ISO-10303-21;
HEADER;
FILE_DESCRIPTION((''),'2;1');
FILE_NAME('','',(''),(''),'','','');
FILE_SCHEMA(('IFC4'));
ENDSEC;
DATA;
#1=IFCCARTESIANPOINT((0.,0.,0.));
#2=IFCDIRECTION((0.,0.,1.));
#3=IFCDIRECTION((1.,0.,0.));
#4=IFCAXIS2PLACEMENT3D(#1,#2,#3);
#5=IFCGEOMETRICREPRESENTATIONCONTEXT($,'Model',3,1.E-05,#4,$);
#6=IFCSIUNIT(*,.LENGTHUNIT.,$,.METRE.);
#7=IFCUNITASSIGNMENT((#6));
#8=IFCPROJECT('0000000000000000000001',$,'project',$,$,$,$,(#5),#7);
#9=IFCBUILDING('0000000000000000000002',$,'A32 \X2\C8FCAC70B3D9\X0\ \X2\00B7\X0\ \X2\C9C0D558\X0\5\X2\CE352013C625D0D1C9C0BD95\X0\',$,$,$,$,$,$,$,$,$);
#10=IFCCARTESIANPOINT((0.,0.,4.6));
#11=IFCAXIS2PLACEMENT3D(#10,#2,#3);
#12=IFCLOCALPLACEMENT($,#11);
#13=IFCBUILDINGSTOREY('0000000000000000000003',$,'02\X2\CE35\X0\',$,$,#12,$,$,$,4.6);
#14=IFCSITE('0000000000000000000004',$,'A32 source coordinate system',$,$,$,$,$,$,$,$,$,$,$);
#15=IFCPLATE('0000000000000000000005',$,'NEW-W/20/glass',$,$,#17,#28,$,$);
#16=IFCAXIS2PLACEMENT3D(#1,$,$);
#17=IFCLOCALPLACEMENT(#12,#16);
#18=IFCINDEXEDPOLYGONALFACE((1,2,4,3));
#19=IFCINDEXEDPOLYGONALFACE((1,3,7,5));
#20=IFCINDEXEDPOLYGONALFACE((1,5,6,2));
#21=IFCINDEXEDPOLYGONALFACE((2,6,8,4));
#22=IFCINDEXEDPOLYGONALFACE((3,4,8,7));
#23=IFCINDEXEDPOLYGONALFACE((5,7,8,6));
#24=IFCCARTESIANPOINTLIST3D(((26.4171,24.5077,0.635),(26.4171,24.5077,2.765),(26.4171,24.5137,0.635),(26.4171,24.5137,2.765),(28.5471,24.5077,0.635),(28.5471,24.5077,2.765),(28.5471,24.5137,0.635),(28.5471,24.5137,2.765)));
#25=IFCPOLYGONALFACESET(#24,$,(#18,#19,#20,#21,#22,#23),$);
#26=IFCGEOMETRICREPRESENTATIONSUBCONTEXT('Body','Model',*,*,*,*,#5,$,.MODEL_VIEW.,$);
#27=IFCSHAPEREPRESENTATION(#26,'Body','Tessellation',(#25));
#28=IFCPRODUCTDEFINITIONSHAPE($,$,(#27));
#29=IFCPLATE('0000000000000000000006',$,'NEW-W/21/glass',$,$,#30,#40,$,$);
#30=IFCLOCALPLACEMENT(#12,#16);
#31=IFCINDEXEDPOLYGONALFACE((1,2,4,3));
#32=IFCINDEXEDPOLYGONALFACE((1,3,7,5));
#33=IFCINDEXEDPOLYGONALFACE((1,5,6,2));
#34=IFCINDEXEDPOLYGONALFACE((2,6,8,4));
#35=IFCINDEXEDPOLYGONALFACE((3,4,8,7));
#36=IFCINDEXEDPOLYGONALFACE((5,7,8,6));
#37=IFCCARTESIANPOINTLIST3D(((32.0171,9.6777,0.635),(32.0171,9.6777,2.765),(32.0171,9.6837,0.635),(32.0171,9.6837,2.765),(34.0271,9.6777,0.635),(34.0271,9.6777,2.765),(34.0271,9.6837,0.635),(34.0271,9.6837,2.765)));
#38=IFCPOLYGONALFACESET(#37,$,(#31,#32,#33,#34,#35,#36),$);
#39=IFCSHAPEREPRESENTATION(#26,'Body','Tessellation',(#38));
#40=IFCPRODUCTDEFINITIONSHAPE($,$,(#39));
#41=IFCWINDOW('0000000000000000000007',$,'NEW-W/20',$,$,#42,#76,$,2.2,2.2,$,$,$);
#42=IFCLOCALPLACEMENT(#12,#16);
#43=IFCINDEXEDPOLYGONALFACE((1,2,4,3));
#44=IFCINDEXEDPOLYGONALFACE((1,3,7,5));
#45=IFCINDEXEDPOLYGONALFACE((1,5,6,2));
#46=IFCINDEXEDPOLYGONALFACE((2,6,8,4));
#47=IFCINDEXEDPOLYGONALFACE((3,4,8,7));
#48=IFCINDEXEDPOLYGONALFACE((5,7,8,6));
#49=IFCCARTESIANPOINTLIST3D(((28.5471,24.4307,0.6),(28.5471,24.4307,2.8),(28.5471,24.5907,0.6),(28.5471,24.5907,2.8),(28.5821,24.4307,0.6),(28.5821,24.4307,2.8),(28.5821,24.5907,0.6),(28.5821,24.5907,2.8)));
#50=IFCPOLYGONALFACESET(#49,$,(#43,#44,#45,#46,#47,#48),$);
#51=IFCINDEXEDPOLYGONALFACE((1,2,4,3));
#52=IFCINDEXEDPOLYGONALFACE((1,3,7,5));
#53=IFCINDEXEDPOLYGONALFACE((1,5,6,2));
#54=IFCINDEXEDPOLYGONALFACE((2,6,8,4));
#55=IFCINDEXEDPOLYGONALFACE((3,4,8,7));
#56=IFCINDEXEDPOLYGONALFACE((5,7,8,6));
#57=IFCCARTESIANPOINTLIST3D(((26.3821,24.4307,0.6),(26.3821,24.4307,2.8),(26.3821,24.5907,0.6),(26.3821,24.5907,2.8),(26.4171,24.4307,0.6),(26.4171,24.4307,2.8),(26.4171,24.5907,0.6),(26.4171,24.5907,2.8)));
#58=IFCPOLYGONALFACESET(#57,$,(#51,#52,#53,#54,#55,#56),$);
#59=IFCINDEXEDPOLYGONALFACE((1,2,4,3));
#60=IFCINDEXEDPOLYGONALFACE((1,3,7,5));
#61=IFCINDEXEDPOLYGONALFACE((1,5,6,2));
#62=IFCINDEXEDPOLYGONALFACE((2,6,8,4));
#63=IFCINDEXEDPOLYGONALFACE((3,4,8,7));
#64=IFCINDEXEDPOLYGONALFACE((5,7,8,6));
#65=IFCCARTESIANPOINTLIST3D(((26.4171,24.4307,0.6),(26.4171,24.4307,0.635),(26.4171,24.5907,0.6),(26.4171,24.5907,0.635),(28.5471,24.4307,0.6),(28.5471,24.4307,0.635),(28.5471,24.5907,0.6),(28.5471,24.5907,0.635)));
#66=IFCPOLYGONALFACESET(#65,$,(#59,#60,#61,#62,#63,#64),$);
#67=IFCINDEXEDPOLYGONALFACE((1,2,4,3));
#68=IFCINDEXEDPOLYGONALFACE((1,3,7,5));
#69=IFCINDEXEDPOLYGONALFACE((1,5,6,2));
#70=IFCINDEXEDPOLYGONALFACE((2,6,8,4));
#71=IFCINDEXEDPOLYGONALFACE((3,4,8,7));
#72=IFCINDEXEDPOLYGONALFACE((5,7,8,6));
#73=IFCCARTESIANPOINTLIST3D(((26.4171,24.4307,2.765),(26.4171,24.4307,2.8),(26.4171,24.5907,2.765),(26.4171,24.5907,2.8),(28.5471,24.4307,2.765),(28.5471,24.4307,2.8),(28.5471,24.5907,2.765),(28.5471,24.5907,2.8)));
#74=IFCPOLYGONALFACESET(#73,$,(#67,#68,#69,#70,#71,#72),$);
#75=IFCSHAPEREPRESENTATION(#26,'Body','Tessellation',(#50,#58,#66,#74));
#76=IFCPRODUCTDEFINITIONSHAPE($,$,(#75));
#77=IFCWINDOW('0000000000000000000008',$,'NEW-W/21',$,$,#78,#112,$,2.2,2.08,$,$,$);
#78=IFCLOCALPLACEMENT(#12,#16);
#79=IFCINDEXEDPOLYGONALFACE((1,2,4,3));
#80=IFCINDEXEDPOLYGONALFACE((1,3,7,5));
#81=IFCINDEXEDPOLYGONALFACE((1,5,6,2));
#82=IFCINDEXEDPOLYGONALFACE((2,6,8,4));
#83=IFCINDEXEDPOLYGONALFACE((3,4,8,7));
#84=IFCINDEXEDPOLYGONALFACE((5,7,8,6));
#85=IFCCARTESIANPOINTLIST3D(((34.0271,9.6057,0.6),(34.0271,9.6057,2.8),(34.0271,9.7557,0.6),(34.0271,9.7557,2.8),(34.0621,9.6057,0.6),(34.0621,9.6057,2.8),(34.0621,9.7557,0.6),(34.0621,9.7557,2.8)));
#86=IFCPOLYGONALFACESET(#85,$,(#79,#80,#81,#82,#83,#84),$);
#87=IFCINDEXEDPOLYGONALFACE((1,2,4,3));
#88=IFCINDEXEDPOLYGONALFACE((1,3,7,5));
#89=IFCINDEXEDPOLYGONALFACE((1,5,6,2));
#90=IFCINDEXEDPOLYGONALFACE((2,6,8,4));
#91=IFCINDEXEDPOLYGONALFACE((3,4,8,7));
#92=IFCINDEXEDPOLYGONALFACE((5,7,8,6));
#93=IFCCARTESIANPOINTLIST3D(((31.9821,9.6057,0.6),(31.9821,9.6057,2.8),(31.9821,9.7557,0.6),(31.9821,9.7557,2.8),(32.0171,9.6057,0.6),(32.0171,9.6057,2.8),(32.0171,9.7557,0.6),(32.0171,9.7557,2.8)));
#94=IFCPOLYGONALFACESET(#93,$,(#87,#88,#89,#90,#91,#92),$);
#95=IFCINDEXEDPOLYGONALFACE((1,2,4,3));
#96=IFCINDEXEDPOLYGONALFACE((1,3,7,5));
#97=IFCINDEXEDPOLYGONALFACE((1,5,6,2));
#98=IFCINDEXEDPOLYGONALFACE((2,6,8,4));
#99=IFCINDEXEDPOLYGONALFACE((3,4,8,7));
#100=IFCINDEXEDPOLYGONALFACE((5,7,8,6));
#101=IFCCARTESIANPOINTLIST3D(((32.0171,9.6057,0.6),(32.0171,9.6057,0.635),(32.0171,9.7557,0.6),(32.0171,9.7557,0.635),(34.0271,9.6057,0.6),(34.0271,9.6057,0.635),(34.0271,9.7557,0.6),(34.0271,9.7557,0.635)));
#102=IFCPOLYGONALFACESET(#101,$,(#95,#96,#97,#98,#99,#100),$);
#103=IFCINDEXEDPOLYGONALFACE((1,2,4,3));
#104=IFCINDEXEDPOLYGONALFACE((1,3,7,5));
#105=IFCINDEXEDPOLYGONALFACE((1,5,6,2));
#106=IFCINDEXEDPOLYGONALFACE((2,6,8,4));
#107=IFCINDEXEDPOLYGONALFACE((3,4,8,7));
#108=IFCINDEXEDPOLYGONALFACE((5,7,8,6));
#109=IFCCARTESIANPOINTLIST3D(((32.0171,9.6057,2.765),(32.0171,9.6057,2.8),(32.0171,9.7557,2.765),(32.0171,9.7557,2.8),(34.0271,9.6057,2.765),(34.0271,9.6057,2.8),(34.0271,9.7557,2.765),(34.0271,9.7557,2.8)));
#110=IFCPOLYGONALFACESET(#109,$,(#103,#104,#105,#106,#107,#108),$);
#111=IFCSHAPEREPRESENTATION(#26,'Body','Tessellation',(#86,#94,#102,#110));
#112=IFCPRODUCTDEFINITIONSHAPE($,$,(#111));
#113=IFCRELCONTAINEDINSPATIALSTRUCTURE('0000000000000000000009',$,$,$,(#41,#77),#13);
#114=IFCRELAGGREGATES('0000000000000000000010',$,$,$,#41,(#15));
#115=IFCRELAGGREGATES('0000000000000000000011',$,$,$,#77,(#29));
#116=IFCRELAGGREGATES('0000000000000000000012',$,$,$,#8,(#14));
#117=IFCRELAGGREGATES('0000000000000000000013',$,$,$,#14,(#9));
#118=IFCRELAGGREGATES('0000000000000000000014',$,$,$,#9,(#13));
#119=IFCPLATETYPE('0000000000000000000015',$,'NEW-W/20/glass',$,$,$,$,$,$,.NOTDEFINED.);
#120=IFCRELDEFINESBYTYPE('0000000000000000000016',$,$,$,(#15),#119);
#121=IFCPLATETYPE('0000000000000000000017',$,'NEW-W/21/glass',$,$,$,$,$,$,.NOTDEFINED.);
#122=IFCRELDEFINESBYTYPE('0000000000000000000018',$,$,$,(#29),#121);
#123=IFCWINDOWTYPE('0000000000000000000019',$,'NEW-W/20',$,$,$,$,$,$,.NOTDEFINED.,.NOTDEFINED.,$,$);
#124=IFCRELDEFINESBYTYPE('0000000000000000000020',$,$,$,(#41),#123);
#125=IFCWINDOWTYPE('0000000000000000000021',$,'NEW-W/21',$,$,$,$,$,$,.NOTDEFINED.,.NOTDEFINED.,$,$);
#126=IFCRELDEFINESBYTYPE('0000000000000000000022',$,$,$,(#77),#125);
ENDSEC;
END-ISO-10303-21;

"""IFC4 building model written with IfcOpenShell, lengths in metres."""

from ifc_helpers import new_model, si_unit, frame, origin, origin_with_axes, place, context, subcontext, project, spatial, polyline, outline, extrude, source, transform, mapped, type_object, type_shapes, element, aggregate, save


model = new_model("IFC4")

# Units and contexts
model_context = context("Model", 3, precision=1e-05, world=origin_with_axes())
body_context = subcontext(model_context, "Body", "Model", "MODEL_VIEW")
ifc_project = project(units=[si_unit("LENGTHUNIT", "METRE")], contexts=[model_context])

# Plates
storey_placement = place(None, frame((0.0, 0.0, 4.6), z_axis=(0.0, 0.0, 1.0), x_axis=(1.0, 0.0, 0.0)))
plate_type_1 = type_object("IfcPlateType", Name="NEW-W/20/glass", PredefinedType="NOTDEFINED")
shared_shape_1 = source(origin(), body_context, "Body", "SweptSolid", [
    extrude(outline(polyline([(28.5471, 24.5077), (26.4171, 24.5077), (26.4171, 24.5137), (28.5471, 24.5137), (28.5471, 24.5077)])), frame((0.0, 0.0, 0.635)), (0.0, 0.0, 1.0), 2.13),
])
type_shapes(plate_type_1, [shared_shape_1])
window_1_placement = place(storey_placement, origin_with_axes())
plate_1_placement = place(window_1_placement, origin_with_axes())
plate_1 = element("IfcPlate", 1, at=plate_1_placement, type_object=plate_type_1, Name="NEW-W/20/glass", context=body_context, shape_type="MappedRepresentation", body=[
    mapped(shared_shape_1, transform((0.0, 0.0, 0.0), scale=1.0)),
])
plate_type_2 = type_object("IfcPlateType", Name="NEW-W/21/glass", PredefinedType="NOTDEFINED")
shared_shape_2 = source(origin(), body_context, "Body", "SweptSolid", [
    extrude(outline(polyline([(34.0271, 9.6777), (32.0171, 9.6777), (32.0171, 9.6837), (34.0271, 9.6837), (34.0271, 9.6777)])), frame((0.0, 0.0, 0.635)), (0.0, 0.0, 1.0), 2.13),
])
type_shapes(plate_type_2, [shared_shape_2])
window_2_placement = place(storey_placement, origin_with_axes())
plate_2_placement = place(window_2_placement, origin_with_axes())
plate_2 = element("IfcPlate", 2, at=plate_2_placement, type_object=plate_type_2, Name="NEW-W/21/glass", context=body_context, shape_type="MappedRepresentation", body=[
    mapped(shared_shape_2, transform((0.0, 0.0, 0.0), scale=1.0)),
])

# Site, building, storey
site = spatial("IfcSite", under=ifc_project, Name="A32 source coordinate system")
building = spatial("IfcBuilding", under=site, Name="A32 주거동 · 지하5층–옥탑지붕")
storey = spatial("IfcBuildingStorey", under=building, at=storey_placement, Name="02층", Elevation=4.6)

# Windows
window_type_1 = type_object("IfcWindowType", Name="NEW-W/20", PartitioningType="NOTDEFINED", PredefinedType="NOTDEFINED")
shared_shape_3 = source(origin(), body_context, "Body", "SweptSolid", [
    extrude(outline(polyline([(28.5471, 24.4307), (28.5471, 24.5907), (28.5821, 24.5907), (28.5821, 24.4307), (28.5471, 24.4307)])), frame((0.0, 0.0, 0.6)), (0.0, 0.0, 1.0), 2.2),
    extrude(outline(polyline([(26.3821, 24.4307), (26.3821, 24.5907), (26.4171, 24.5907), (26.4171, 24.4307), (26.3821, 24.4307)])), frame((0.0, 0.0, 0.6)), (0.0, 0.0, 1.0), 2.2),
    extrude(outline(polyline([(28.5471, 24.4307), (28.5471, 24.5907), (26.4171, 24.5907), (26.4171, 24.4307), (28.5471, 24.4307)])), frame((0.0, 0.0, 0.6)), (0.0, 0.0, 1.0), 0.035),
    extrude(outline(polyline([(28.5471, 24.4307), (28.5471, 24.5907), (26.4171, 24.5907), (26.4171, 24.4307), (28.5471, 24.4307)])), frame((0.0, 0.0, 2.765)), (0.0, 0.0, 1.0), 0.035),
])
type_shapes(window_type_1, [shared_shape_3])
window_1 = element("IfcWindow", 3, at=window_1_placement, inside=storey, type_object=window_type_1, Name="NEW-W/20", OverallHeight=2.2, OverallWidth=2.2, context=body_context, shape_type="MappedRepresentation", body=[
    mapped(shared_shape_3, transform((0.0, 0.0, 0.0), scale=1.0)),
])
aggregate(window_1, [plate_1])
window_type_2 = type_object("IfcWindowType", Name="NEW-W/21", PartitioningType="NOTDEFINED", PredefinedType="NOTDEFINED")
shared_shape_4 = source(origin(), body_context, "Body", "SweptSolid", [
    extrude(outline(polyline([(34.0271, 9.6057), (34.0271, 9.7557), (34.0621, 9.7557), (34.0621, 9.6057), (34.0271, 9.6057)])), frame((0.0, 0.0, 0.6)), (0.0, 0.0, 1.0), 2.2),
    extrude(outline(polyline([(31.9821, 9.6057), (31.9821, 9.7557), (32.0171, 9.7557), (32.0171, 9.6057), (31.9821, 9.6057)])), frame((0.0, 0.0, 0.6)), (0.0, 0.0, 1.0), 2.2),
    extrude(outline(polyline([(34.0271, 9.6057), (34.0271, 9.7557), (32.0171, 9.7557), (32.0171, 9.6057), (34.0271, 9.6057)])), frame((0.0, 0.0, 0.6)), (0.0, 0.0, 1.0), 0.035),
    extrude(outline(polyline([(34.0271, 9.6057), (34.0271, 9.7557), (32.0171, 9.7557), (32.0171, 9.6057), (34.0271, 9.6057)])), frame((0.0, 0.0, 2.765)), (0.0, 0.0, 1.0), 0.035),
])
type_shapes(window_type_2, [shared_shape_4])
window_2 = element("IfcWindow", 4, at=window_2_placement, inside=storey, type_object=window_type_2, Name="NEW-W/21", OverallHeight=2.2, OverallWidth=2.08, context=body_context, shape_type="MappedRepresentation", body=[
    mapped(shared_shape_4, transform((0.0, 0.0, 0.0), scale=1.0)),
])
aggregate(window_2, [plate_2])

save(model, "model.ifc")
